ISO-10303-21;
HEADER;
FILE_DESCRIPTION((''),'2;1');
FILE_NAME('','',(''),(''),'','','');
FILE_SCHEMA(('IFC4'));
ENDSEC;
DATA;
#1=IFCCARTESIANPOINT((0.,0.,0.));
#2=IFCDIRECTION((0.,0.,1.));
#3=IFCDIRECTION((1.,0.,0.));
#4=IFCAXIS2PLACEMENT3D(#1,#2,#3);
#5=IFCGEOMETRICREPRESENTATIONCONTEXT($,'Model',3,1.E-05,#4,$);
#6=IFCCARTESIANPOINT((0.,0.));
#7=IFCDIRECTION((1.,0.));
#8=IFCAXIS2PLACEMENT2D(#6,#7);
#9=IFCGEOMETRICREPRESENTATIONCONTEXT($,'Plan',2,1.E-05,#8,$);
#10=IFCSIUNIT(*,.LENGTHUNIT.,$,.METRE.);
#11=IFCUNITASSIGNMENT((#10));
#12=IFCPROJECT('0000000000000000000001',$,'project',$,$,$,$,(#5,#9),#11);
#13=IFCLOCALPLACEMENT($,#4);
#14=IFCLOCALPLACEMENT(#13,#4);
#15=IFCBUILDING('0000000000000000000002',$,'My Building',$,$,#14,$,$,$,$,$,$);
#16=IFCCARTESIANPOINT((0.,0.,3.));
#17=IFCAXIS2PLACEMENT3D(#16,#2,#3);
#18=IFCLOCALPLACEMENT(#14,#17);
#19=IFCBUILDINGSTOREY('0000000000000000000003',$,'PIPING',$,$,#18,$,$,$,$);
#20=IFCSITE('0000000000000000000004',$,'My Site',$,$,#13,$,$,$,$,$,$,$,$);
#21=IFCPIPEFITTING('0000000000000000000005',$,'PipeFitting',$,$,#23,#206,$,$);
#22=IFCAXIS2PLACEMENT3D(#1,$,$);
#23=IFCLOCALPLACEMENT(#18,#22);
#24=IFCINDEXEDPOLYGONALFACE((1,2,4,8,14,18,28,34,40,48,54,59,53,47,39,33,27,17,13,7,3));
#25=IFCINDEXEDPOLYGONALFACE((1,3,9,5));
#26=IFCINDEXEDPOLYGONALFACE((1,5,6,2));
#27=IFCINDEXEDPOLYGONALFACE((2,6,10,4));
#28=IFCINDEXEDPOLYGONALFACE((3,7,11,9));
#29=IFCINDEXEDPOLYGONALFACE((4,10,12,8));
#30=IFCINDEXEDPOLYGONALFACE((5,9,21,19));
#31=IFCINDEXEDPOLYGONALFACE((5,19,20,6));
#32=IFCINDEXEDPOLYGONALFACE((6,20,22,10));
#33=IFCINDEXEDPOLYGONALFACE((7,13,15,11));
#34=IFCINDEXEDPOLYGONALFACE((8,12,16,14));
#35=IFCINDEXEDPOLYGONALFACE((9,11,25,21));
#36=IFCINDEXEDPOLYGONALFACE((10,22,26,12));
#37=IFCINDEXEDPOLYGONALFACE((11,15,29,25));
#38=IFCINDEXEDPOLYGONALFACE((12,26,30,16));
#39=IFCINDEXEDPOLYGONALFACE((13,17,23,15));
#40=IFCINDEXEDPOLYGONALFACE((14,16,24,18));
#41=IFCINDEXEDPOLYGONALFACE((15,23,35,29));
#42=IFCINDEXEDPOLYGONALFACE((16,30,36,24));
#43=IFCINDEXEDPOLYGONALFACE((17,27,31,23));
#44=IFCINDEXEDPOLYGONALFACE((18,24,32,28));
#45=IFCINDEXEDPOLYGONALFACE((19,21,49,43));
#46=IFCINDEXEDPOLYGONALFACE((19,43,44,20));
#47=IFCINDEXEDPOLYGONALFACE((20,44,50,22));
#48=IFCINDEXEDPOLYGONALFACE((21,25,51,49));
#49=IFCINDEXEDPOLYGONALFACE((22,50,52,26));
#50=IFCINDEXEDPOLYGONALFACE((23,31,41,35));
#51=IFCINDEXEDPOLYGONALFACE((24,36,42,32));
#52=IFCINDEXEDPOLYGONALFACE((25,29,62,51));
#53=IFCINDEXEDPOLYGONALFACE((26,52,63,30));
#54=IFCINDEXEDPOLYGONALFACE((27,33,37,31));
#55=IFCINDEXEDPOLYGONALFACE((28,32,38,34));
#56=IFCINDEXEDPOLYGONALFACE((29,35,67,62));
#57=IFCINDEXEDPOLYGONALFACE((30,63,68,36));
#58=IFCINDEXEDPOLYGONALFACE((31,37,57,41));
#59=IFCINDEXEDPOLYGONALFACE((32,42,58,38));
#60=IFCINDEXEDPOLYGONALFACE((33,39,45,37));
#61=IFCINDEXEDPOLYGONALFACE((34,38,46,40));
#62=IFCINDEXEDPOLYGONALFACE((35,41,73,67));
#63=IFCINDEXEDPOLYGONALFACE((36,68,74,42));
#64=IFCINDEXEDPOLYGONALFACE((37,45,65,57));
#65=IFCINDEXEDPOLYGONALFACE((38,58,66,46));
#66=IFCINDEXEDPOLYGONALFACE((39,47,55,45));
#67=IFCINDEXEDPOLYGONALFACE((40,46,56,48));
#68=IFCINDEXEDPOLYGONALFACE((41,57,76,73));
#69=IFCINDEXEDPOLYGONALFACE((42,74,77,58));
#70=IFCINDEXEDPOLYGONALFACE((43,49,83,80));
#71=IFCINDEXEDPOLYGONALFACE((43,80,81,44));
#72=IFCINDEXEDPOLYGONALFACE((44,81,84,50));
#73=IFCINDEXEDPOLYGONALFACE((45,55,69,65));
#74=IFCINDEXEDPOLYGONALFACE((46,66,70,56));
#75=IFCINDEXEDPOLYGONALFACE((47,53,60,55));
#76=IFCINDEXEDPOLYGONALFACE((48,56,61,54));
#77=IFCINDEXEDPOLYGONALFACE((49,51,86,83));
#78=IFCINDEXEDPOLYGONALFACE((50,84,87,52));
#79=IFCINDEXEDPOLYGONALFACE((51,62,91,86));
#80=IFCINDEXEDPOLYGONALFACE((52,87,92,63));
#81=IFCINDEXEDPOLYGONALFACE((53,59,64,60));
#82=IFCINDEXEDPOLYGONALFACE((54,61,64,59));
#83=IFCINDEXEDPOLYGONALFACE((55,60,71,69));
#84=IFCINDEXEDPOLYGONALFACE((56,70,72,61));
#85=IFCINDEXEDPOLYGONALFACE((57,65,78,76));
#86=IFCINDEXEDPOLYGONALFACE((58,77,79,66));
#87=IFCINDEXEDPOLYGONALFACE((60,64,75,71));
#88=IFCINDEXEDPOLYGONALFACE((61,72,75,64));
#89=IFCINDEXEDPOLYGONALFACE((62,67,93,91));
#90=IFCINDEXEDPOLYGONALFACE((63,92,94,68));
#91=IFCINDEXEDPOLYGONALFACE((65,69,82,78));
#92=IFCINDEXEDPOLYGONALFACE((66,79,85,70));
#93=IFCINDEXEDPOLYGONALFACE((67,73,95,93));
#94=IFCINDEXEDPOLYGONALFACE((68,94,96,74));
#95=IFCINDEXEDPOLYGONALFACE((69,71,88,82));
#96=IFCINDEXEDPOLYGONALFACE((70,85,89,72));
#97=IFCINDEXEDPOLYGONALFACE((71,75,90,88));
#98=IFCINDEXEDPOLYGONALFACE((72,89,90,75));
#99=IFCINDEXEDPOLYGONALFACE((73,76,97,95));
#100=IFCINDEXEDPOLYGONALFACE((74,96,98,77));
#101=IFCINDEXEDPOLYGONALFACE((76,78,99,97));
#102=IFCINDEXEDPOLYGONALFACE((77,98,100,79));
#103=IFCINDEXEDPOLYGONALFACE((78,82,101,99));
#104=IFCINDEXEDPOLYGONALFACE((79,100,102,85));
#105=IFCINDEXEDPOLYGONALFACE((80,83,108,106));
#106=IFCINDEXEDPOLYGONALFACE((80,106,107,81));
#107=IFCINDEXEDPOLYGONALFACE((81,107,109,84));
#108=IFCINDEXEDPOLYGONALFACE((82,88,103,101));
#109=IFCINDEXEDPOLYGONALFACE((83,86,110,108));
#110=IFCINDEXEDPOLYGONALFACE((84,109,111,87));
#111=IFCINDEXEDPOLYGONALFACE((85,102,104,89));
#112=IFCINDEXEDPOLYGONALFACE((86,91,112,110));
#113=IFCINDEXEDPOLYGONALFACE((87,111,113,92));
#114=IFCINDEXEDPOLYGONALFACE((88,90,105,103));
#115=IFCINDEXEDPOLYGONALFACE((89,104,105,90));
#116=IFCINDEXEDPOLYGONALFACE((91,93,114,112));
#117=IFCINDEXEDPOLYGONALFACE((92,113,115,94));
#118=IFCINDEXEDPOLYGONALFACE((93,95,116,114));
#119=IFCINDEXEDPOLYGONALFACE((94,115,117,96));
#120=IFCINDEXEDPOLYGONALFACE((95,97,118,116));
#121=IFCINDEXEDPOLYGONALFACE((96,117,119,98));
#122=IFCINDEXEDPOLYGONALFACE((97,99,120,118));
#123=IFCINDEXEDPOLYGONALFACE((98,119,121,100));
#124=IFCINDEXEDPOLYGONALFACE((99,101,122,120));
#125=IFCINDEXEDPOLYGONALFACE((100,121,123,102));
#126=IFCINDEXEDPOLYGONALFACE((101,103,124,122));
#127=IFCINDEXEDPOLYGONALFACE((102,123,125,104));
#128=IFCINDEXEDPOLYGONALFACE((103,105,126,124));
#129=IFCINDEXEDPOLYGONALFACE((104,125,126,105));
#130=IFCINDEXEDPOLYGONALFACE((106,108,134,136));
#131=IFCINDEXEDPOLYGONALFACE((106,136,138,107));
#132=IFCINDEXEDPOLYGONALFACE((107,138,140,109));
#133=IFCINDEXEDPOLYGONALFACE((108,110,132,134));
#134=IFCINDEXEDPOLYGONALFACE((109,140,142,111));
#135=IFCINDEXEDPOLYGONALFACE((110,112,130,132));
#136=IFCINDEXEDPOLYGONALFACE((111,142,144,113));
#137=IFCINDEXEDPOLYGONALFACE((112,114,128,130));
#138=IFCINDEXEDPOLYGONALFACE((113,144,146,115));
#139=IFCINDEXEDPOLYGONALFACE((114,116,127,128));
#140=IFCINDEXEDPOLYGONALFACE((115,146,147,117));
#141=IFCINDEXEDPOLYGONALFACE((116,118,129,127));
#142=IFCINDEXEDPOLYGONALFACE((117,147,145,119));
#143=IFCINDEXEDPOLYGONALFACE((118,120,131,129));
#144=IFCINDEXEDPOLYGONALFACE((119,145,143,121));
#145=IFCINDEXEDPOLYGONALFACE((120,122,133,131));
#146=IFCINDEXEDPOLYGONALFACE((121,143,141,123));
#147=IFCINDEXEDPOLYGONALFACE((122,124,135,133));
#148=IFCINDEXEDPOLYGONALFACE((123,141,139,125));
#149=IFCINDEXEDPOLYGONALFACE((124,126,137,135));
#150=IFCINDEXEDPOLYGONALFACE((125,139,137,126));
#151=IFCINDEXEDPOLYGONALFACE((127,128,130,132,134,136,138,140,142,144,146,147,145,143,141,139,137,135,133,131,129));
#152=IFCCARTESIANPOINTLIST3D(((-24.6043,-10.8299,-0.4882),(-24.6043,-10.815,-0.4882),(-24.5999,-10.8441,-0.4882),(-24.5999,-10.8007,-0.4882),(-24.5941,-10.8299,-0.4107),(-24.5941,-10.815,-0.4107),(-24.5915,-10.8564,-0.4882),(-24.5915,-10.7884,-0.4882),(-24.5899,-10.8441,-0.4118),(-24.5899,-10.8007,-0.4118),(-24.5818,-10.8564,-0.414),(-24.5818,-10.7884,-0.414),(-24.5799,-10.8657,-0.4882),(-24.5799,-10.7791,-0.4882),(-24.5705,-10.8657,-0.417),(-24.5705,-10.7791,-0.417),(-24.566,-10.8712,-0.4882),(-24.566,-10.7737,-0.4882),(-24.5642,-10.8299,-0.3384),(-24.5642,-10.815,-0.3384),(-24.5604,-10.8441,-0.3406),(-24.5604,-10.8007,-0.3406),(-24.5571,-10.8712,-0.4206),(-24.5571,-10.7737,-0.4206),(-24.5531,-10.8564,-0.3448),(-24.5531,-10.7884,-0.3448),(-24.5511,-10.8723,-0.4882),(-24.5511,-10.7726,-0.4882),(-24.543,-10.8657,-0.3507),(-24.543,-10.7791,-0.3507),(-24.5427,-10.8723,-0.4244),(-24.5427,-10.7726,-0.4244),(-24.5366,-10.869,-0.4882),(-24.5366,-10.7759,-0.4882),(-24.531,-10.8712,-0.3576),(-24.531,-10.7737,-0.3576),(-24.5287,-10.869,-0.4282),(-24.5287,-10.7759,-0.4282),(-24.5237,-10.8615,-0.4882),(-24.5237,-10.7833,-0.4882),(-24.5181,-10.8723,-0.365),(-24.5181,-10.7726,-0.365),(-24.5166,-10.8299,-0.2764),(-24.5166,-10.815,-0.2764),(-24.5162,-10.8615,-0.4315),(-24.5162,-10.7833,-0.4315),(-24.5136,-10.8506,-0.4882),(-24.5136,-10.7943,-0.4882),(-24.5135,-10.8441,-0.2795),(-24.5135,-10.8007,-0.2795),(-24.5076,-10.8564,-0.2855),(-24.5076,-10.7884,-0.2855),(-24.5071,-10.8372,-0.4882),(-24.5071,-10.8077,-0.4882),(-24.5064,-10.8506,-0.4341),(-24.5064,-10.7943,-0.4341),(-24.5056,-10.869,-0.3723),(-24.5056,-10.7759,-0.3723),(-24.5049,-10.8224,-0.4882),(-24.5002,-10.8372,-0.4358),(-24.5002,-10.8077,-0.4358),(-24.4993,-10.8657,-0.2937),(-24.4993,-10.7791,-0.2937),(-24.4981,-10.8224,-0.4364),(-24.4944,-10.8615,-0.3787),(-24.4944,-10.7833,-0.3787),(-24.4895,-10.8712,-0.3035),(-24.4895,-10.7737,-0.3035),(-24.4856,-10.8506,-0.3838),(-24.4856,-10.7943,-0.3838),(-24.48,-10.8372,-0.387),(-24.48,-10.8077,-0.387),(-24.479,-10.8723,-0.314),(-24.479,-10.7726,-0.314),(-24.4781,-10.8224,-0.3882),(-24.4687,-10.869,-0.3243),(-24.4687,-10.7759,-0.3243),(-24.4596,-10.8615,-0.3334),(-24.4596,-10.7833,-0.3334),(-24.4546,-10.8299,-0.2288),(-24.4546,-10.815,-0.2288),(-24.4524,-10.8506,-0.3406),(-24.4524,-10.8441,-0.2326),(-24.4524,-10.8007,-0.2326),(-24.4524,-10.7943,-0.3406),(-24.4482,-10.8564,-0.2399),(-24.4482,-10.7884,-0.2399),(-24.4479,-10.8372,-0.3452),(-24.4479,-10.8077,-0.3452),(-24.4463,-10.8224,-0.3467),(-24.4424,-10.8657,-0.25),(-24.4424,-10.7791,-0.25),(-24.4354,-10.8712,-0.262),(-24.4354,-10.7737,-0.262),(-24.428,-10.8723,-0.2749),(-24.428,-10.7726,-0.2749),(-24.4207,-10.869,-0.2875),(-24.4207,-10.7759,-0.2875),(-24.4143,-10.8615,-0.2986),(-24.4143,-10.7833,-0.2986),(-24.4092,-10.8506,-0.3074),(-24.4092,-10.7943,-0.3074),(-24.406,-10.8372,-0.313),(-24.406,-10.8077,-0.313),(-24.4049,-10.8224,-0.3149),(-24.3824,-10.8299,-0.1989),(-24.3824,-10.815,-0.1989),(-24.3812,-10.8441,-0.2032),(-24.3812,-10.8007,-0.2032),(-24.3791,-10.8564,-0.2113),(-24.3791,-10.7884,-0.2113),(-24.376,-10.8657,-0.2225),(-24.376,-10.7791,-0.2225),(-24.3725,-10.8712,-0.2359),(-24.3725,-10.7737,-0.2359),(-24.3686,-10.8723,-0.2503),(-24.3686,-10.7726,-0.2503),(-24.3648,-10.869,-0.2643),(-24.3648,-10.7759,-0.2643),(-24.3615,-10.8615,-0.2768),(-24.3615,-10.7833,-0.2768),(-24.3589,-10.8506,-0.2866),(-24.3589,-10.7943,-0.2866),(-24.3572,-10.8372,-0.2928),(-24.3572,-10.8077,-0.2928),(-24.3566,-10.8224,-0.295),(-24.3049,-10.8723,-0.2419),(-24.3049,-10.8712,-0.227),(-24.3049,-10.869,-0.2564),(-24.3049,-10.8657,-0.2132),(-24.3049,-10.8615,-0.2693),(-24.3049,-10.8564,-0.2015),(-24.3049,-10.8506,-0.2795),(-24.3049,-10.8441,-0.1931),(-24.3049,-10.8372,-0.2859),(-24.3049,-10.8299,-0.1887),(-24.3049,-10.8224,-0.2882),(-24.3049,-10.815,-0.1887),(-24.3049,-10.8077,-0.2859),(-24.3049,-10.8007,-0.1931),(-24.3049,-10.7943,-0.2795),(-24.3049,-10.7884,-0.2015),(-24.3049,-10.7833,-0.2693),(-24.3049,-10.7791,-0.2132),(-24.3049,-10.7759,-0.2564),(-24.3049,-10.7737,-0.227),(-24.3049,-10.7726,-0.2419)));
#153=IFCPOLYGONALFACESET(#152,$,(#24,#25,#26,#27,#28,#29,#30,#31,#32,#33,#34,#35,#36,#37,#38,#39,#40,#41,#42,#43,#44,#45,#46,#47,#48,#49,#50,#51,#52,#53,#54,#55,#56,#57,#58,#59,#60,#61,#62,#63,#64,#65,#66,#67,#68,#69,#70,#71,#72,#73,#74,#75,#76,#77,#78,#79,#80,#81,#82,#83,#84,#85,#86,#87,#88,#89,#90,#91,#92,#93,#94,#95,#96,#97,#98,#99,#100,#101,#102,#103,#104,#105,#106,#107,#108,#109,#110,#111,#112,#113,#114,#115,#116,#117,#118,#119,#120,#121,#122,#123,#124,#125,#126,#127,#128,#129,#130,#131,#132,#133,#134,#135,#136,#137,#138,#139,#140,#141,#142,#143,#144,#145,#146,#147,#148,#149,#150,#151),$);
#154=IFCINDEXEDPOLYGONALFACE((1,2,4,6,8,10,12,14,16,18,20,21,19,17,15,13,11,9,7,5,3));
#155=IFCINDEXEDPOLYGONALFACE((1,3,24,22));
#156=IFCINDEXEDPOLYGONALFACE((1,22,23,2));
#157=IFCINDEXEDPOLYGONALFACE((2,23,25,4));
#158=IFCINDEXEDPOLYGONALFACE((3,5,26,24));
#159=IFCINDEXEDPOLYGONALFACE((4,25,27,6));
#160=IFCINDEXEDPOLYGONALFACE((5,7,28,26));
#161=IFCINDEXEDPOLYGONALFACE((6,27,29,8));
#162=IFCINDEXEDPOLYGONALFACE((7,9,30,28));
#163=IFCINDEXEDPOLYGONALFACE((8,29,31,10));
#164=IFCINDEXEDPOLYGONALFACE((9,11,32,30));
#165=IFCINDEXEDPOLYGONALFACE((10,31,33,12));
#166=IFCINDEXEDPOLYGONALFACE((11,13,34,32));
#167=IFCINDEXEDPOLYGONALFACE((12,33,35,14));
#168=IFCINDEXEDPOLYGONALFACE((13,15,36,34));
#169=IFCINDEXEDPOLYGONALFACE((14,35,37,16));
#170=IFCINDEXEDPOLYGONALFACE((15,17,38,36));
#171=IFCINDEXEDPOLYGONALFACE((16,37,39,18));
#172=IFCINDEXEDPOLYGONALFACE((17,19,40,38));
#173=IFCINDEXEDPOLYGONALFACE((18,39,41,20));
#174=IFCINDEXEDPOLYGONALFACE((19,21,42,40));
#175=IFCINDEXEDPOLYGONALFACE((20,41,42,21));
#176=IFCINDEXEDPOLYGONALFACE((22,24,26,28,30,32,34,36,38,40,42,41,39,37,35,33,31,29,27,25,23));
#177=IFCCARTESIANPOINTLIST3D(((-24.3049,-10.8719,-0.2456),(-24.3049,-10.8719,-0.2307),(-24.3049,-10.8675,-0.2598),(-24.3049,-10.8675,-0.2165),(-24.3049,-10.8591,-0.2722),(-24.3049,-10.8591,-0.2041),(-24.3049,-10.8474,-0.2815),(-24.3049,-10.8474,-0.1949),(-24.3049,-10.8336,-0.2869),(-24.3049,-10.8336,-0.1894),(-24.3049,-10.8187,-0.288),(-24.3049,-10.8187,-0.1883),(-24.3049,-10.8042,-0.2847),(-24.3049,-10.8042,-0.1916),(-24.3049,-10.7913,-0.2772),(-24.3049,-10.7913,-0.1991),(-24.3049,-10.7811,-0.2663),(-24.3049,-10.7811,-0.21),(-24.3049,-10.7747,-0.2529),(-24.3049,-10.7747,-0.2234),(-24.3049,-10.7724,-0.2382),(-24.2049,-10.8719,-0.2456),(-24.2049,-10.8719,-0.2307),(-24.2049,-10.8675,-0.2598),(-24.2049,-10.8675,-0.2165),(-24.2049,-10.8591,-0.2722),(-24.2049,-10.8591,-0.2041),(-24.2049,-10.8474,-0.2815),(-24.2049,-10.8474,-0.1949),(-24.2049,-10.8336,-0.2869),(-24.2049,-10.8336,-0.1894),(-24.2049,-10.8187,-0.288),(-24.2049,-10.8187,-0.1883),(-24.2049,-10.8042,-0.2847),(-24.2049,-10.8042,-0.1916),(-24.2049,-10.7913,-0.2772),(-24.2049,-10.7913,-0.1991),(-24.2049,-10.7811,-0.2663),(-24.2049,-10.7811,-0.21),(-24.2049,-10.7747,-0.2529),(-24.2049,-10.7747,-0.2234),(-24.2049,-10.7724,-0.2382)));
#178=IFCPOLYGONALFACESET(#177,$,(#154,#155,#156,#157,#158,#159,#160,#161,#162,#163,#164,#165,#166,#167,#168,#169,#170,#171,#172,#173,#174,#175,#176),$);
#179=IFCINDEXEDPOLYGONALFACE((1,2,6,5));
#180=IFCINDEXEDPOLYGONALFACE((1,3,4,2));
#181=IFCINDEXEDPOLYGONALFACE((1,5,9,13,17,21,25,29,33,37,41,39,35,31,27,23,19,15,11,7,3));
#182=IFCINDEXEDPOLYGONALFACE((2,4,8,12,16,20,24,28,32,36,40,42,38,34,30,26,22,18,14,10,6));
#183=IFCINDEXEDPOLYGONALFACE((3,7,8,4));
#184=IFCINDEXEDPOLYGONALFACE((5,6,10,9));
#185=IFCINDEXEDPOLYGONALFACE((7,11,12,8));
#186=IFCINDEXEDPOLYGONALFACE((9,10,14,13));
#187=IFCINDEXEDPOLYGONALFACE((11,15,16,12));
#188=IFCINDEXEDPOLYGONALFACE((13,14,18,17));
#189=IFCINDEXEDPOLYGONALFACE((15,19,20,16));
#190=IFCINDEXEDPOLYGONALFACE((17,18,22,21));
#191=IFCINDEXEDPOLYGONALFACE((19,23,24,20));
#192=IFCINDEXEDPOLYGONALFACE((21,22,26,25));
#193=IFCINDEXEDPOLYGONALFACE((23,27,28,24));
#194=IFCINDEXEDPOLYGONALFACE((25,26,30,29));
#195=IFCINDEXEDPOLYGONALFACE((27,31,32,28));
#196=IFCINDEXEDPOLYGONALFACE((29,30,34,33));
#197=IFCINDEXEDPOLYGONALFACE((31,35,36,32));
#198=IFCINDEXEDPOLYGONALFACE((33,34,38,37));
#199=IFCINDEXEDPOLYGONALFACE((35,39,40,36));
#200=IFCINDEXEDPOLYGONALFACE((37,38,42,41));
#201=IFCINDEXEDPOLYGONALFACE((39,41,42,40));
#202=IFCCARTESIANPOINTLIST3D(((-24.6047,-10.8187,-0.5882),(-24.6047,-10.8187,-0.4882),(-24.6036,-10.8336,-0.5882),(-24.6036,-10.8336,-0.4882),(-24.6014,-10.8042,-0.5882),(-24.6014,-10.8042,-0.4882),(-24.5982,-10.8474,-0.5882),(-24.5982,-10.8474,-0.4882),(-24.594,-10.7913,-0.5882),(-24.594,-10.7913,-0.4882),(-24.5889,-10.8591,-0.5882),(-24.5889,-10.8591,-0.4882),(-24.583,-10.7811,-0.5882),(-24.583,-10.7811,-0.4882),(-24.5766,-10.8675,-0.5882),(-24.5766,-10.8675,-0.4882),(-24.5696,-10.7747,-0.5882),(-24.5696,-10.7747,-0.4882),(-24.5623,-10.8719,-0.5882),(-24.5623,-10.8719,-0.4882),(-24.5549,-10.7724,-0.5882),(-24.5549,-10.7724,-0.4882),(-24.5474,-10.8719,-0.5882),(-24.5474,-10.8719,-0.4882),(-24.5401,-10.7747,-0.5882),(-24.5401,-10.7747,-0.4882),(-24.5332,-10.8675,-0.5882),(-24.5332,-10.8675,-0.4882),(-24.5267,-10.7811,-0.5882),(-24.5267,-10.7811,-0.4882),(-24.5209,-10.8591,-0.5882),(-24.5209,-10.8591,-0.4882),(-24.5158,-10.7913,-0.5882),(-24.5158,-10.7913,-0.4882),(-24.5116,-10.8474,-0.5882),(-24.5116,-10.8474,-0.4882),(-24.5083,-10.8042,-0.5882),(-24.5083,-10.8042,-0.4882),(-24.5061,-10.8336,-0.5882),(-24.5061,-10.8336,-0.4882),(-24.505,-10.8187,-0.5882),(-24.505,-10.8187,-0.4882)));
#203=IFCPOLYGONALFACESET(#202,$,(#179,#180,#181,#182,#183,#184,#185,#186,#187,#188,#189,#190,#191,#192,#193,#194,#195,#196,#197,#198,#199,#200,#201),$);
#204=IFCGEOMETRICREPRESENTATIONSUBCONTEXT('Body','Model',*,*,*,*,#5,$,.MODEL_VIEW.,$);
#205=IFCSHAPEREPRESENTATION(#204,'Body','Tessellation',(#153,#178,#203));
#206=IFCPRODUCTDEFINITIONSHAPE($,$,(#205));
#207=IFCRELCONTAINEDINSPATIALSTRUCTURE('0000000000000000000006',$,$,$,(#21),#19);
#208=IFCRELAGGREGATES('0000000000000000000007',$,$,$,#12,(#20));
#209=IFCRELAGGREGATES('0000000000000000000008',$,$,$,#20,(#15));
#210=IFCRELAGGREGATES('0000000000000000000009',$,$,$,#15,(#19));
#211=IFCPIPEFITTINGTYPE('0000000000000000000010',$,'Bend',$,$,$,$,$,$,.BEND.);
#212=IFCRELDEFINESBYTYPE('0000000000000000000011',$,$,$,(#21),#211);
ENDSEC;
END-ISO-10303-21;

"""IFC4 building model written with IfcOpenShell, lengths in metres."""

from ifc_helpers import new_model, entity, si_unit, frame, origin_with_axes, origin_2d_with_axis, place, context, subcontext, project, spatial, circle, extrude, source, transform, mapped, type_object, type_shapes, element, save


model = new_model("IFC4")

# Units and contexts
model_context = context("Model", 3, precision=1e-05, world=origin_with_axes())
plan_context = context("Plan", 2, precision=1e-05, world=origin_2d_with_axis())
body_context = subcontext(model_context, "Body", "Model", "MODEL_VIEW")
ifc_project = project(units=[si_unit("LENGTHUNIT", "METRE")], contexts=[model_context, plan_context])

# Site, building, storey
site_placement = place(None, origin_with_axes())
site = spatial("IfcSite", under=ifc_project, at=site_placement, Name="My Site")
building_placement = place(site_placement, origin_with_axes())
building = spatial("IfcBuilding", under=site, at=building_placement, Name="My Building")
storey_placement = place(building_placement, frame((0.0, 0.0, 3.0), z_axis=(0.0, 0.0, 1.0), x_axis=(1.0, 0.0, 0.0)))
storey = spatial("IfcBuildingStorey", under=building, at=storey_placement, Name="PIPING")

# Pipe fitting
pipe_fitting_type = type_object("IfcPipeFittingType", Name="Bend", PredefinedType="BEND")
shared_shape = source(origin_with_axes(), body_context, "Body", "SolidModel", [
    entity("IfcSweptDiskSolid", entity("IfcIndexedPolyCurve", entity("IfcCartesianPointList3D", [[0.0, 0.0, -0.1], [0.0, -0.0732, -0.2768], [0.0, -0.25, -0.35]]), [entity("IfcArcIndex", [1, 2, 3])]), 0.05),
    extrude(circle(Radius=0.05), origin_with_axes(), (0.0, 0.0, -1.0), 0.1),
    extrude(circle(Radius=0.05), frame((0.0, -0.25, -0.35), z_axis=(0.0, -1.0, 0.0), x_axis=(1.0, 0.0, 0.0)), (0.0, 0.0, 1.0), 0.1),
])
type_shapes(pipe_fitting_type, [shared_shape])
for number, where, z_axis, x_axis, name in (
    (1, (-24.2049, -10.8224, -0.2382), (1.0, 0.0, 0.0), (0.0, 1.0, 0.0), "PipeFitting"),
):
    element("IfcPipeFitting", number, at=place(storey_placement, frame(where, z_axis=z_axis, x_axis=x_axis)), inside=storey, type_object=pipe_fitting_type, Name=name, context=body_context, shape_type="MappedRepresentation", body=[
        mapped(shared_shape, transform((0.0, 0.0, 0.0), x_axis=(1.0, 0.0, 0.0), y_axis=(0.0, 1.0, 0.0), z_axis=(0.0, 0.0, 1.0), scale=1.0)),
    ])

save(model, "model.ifc")
